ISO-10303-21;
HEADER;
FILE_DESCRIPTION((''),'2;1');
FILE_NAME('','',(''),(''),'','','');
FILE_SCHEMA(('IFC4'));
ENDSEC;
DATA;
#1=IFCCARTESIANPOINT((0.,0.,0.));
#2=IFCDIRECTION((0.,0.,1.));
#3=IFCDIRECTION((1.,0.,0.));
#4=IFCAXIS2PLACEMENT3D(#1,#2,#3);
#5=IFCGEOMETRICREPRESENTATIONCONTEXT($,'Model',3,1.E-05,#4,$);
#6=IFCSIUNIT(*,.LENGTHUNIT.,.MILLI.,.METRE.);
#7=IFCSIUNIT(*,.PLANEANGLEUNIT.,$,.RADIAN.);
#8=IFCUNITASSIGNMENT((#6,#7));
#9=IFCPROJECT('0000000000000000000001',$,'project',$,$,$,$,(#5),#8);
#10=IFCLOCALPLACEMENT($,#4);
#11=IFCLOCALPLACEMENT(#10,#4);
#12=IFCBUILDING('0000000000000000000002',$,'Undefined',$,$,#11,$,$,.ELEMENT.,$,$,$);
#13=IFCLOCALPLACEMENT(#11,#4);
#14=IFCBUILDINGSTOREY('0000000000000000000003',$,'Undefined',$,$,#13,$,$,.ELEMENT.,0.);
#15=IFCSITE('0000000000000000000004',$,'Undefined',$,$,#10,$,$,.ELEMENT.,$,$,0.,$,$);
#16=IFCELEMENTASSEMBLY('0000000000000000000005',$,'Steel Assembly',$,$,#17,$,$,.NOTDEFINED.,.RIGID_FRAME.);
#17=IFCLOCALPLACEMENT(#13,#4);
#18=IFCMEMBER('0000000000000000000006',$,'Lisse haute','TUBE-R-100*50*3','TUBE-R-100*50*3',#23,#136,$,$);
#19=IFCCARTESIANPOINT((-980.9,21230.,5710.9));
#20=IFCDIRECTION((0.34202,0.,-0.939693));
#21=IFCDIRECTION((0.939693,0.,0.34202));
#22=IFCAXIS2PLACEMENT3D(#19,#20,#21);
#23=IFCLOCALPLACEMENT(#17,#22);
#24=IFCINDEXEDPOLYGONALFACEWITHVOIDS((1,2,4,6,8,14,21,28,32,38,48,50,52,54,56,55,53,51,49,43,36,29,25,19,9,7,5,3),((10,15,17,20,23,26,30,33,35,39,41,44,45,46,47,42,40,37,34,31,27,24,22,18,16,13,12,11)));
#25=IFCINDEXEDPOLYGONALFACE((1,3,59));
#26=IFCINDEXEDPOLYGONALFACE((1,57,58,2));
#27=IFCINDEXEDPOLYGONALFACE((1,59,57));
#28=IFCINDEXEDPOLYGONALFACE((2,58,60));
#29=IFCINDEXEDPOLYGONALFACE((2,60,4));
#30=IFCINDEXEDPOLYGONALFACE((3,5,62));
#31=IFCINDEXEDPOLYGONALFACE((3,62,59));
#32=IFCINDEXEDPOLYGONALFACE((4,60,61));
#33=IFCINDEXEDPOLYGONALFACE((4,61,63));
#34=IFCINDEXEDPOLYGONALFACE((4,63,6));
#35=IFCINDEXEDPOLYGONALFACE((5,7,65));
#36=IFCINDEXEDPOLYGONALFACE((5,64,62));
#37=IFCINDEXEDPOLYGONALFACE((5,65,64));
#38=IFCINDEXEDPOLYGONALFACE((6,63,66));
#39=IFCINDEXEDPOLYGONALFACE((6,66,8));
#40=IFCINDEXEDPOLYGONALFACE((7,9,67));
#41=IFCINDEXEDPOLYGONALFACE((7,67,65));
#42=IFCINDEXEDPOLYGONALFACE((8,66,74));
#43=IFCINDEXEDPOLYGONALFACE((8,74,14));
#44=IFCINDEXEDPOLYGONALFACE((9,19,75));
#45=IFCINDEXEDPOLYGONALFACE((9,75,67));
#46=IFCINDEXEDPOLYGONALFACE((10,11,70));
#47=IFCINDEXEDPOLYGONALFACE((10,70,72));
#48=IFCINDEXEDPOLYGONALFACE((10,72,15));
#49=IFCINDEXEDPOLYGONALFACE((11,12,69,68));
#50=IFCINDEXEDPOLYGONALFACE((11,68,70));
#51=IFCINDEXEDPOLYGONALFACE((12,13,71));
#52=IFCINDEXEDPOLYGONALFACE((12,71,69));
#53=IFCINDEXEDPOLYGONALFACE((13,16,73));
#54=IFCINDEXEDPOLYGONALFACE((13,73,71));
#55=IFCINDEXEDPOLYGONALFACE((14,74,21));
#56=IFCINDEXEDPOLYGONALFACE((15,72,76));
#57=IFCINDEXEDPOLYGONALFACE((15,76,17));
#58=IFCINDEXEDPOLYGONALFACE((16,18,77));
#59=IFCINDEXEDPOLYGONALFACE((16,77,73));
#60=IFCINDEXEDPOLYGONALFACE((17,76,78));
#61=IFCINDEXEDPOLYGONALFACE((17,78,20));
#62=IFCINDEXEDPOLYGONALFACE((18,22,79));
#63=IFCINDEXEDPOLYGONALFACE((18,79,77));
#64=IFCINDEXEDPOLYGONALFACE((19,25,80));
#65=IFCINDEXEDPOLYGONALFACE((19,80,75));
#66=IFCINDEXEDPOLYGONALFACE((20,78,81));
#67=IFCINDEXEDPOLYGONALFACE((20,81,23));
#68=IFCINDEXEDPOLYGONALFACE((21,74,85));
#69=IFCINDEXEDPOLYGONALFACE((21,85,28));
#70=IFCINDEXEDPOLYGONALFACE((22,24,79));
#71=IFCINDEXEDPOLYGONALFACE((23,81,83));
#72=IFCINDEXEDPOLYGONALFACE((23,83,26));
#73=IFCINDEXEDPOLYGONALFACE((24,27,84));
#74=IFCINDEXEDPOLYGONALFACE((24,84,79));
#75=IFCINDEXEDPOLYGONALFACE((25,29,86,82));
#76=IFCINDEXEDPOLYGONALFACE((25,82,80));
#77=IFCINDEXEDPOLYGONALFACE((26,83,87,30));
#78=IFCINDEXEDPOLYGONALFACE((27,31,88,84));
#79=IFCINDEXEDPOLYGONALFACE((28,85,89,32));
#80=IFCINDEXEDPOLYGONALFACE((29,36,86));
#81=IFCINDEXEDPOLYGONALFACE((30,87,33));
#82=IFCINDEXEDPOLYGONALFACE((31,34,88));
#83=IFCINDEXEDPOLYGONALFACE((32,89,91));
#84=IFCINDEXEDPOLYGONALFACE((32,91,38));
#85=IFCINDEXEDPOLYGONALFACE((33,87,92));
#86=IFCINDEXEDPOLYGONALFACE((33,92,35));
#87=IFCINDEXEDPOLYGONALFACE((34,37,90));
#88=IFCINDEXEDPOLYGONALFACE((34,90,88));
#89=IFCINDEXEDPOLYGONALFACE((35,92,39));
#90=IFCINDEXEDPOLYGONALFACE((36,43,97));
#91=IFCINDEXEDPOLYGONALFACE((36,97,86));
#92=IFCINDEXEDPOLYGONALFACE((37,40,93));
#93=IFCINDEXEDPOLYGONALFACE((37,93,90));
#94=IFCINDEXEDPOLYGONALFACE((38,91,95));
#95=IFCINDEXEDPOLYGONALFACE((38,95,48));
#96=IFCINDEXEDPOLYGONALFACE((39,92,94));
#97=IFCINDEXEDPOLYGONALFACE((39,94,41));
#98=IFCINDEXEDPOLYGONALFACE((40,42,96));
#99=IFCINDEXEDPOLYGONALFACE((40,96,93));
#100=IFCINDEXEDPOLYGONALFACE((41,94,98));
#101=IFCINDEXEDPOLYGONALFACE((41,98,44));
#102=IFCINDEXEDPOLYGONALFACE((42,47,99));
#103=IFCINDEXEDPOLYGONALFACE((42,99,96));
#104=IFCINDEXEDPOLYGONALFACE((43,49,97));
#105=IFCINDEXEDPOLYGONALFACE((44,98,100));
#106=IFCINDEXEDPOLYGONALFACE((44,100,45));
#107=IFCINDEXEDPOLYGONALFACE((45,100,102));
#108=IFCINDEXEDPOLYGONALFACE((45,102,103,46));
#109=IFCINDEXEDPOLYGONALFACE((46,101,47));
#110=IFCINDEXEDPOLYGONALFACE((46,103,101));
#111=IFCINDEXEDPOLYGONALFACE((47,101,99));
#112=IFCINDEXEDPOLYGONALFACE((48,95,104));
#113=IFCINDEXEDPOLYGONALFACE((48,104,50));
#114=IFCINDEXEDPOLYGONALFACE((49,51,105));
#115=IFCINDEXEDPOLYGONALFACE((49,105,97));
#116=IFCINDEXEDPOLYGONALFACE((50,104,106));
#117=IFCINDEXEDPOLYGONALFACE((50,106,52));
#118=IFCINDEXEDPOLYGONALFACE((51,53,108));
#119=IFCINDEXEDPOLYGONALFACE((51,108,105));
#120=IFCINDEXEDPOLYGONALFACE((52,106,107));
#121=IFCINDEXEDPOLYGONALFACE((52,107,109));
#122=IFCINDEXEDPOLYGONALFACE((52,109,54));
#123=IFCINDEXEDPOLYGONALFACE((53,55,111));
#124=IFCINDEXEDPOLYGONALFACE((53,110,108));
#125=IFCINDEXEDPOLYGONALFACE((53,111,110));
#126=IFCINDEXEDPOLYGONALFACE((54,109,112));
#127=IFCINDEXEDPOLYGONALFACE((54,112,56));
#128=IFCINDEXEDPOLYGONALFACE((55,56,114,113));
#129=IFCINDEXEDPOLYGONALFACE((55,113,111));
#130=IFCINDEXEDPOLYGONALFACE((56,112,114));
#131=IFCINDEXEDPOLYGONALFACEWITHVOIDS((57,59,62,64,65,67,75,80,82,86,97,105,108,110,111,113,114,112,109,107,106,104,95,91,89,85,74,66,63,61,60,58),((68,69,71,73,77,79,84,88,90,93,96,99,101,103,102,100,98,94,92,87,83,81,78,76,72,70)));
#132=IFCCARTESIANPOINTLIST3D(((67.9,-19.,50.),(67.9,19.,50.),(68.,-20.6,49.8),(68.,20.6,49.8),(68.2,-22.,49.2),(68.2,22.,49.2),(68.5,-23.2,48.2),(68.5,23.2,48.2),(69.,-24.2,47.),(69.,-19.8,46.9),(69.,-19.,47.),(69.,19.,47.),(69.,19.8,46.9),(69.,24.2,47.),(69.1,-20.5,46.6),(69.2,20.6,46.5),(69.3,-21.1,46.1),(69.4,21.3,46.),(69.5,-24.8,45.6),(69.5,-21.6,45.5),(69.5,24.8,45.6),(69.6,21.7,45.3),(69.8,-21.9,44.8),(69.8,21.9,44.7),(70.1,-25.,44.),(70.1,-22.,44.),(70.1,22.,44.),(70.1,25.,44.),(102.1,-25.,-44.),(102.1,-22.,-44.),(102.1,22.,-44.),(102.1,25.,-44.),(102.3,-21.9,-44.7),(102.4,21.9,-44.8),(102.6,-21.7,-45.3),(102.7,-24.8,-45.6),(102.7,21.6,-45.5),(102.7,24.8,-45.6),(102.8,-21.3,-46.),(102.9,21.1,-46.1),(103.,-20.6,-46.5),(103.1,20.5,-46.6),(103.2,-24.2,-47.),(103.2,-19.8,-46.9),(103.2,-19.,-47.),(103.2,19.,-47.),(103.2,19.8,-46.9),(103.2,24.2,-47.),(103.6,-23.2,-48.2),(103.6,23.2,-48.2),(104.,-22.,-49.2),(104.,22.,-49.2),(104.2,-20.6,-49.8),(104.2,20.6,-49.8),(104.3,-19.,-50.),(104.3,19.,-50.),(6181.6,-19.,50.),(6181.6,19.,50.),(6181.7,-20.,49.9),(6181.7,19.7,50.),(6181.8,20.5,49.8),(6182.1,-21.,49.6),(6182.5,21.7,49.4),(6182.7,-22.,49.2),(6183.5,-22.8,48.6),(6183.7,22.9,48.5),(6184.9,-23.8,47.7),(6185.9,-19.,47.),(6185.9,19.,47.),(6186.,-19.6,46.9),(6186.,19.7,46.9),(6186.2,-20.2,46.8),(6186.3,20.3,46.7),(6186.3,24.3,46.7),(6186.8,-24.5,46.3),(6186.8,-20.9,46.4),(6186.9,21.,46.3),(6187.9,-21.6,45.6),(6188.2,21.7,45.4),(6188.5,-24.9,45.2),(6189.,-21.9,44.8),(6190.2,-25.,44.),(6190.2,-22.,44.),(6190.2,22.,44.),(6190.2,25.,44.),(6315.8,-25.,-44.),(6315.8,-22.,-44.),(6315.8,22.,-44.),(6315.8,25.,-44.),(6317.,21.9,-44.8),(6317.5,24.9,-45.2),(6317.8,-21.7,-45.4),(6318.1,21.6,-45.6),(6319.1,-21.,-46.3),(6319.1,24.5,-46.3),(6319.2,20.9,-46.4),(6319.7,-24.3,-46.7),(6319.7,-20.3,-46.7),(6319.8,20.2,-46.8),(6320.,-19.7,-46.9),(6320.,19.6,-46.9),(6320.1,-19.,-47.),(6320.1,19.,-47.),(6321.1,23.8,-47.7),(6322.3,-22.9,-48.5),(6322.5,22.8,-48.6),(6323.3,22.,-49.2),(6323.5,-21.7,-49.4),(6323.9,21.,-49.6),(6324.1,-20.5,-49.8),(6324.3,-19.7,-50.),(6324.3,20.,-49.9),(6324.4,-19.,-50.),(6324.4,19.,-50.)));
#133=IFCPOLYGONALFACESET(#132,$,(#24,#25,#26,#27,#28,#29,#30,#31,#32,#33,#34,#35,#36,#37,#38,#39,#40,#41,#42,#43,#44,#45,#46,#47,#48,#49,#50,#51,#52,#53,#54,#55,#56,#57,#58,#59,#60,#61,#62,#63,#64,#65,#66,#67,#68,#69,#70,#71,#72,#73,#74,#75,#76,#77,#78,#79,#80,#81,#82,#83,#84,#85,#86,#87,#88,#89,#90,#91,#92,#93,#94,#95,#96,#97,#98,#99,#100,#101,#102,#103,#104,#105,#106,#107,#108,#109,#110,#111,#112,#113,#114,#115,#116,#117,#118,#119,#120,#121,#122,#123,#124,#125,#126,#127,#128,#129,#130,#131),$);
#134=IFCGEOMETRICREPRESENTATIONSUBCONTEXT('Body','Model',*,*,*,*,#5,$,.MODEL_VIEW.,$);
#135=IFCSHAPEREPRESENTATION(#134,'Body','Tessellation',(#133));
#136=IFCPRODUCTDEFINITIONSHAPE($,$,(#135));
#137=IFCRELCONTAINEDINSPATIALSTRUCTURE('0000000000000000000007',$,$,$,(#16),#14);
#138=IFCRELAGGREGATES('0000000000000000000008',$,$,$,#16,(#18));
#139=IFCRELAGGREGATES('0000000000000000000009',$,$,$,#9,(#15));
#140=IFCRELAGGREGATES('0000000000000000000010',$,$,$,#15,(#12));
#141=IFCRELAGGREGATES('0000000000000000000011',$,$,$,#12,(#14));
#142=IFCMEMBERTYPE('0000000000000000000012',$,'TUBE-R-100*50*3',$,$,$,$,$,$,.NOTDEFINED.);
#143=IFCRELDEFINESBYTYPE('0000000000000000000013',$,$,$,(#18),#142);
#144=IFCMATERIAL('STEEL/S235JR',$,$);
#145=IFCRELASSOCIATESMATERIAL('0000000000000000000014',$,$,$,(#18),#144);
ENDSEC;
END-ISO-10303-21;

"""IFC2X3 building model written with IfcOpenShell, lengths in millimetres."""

from ifc_helpers import new_model, si_unit, frame, origin_with_axes, origin_2d_with_axis, place, context, subcontext, project, spatial, hollow_rectangle, extrude, clip, halfspace, material, type_object, element, aggregate, save


model = new_model("IFC2X3")

# Units and contexts
model_context = context("Model", 3, precision=1e-05, world=origin_with_axes())
body_context = subcontext(model_context, "Body", "Model", "MODEL_VIEW")
ifc_project = project(units=[si_unit("LENGTHUNIT", "METRE", prefix="MILLI"), si_unit("PLANEANGLEUNIT", "RADIAN")], contexts=[model_context])

# Site, building, storey
site_placement = place(None, origin_with_axes())
site = spatial("IfcSite", under=ifc_project, at=site_placement, Name="Undefined", CompositionType="ELEMENT", RefElevation=0.0)
building_placement = place(site_placement, origin_with_axes())
building = spatial("IfcBuilding", under=site, at=building_placement, Name="Undefined", CompositionType="ELEMENT")
storey_placement = place(building_placement, origin_with_axes())
storey = spatial("IfcBuildingStorey", under=building, at=storey_placement, Name="Undefined", CompositionType="ELEMENT", Elevation=0.0)

# Element assembly, member
ifc_material_1 = material(Name="STEEL/S235JR")
assembly_1_placement = place(storey_placement, origin_with_axes())
assembly_1 = element("IfcElementAssembly", 1, at=assembly_1_placement, inside=storey, Name="Steel Assembly", AssemblyPlace="NOTDEFINED", PredefinedType="RIGID_FRAME")
member_type_1 = type_object("IfcMemberType", Name="TUBE-R-100*50*3", PredefinedType="NOTDEFINED")
member_1_placement = place(assembly_1_placement, frame((-980.9, 21230.0, 5710.9), z_axis=(0.34202, 0.0, -0.939693), x_axis=(0.939693, 0.0, 0.34202)))
member_1 = element("IfcMember", 2, at=member_1_placement, type_object=member_type_1, material=ifc_material_1, Name="Lisse haute", Description="TUBE-R-100*50*3", ObjectType="TUBE-R-100*50*3", context=body_context, shape_type="Clipping", body=[
    clip(clip(extrude(hollow_rectangle(XDim=50.0, YDim=100.0, WallThickness=3.0, InnerFilletRadius=3.0, OuterFilletRadius=6.0, at=origin_2d_with_axis()), frame((6343.5, 0.0, 0.0), z_axis=(-1.0, 0.0, 0.0), x_axis=(0.0, -1.0, 0.0)), (0.0, 0.0, 1.0), 6347.9), halfspace(frame((6181.6, 25.0, 50.0), z_axis=(0.573576, 0.0, 0.819152), x_axis=(0.0, 1.0, 0.0)), False)), halfspace(frame((59.0, 0.0, 74.4), z_axis=(-0.939693, 0.0, -0.34202), x_axis=(0.34202, 0.0, -0.939693)), False)),
])

aggregate(assembly_1, [member_1])

save(model, "model.ifc")
